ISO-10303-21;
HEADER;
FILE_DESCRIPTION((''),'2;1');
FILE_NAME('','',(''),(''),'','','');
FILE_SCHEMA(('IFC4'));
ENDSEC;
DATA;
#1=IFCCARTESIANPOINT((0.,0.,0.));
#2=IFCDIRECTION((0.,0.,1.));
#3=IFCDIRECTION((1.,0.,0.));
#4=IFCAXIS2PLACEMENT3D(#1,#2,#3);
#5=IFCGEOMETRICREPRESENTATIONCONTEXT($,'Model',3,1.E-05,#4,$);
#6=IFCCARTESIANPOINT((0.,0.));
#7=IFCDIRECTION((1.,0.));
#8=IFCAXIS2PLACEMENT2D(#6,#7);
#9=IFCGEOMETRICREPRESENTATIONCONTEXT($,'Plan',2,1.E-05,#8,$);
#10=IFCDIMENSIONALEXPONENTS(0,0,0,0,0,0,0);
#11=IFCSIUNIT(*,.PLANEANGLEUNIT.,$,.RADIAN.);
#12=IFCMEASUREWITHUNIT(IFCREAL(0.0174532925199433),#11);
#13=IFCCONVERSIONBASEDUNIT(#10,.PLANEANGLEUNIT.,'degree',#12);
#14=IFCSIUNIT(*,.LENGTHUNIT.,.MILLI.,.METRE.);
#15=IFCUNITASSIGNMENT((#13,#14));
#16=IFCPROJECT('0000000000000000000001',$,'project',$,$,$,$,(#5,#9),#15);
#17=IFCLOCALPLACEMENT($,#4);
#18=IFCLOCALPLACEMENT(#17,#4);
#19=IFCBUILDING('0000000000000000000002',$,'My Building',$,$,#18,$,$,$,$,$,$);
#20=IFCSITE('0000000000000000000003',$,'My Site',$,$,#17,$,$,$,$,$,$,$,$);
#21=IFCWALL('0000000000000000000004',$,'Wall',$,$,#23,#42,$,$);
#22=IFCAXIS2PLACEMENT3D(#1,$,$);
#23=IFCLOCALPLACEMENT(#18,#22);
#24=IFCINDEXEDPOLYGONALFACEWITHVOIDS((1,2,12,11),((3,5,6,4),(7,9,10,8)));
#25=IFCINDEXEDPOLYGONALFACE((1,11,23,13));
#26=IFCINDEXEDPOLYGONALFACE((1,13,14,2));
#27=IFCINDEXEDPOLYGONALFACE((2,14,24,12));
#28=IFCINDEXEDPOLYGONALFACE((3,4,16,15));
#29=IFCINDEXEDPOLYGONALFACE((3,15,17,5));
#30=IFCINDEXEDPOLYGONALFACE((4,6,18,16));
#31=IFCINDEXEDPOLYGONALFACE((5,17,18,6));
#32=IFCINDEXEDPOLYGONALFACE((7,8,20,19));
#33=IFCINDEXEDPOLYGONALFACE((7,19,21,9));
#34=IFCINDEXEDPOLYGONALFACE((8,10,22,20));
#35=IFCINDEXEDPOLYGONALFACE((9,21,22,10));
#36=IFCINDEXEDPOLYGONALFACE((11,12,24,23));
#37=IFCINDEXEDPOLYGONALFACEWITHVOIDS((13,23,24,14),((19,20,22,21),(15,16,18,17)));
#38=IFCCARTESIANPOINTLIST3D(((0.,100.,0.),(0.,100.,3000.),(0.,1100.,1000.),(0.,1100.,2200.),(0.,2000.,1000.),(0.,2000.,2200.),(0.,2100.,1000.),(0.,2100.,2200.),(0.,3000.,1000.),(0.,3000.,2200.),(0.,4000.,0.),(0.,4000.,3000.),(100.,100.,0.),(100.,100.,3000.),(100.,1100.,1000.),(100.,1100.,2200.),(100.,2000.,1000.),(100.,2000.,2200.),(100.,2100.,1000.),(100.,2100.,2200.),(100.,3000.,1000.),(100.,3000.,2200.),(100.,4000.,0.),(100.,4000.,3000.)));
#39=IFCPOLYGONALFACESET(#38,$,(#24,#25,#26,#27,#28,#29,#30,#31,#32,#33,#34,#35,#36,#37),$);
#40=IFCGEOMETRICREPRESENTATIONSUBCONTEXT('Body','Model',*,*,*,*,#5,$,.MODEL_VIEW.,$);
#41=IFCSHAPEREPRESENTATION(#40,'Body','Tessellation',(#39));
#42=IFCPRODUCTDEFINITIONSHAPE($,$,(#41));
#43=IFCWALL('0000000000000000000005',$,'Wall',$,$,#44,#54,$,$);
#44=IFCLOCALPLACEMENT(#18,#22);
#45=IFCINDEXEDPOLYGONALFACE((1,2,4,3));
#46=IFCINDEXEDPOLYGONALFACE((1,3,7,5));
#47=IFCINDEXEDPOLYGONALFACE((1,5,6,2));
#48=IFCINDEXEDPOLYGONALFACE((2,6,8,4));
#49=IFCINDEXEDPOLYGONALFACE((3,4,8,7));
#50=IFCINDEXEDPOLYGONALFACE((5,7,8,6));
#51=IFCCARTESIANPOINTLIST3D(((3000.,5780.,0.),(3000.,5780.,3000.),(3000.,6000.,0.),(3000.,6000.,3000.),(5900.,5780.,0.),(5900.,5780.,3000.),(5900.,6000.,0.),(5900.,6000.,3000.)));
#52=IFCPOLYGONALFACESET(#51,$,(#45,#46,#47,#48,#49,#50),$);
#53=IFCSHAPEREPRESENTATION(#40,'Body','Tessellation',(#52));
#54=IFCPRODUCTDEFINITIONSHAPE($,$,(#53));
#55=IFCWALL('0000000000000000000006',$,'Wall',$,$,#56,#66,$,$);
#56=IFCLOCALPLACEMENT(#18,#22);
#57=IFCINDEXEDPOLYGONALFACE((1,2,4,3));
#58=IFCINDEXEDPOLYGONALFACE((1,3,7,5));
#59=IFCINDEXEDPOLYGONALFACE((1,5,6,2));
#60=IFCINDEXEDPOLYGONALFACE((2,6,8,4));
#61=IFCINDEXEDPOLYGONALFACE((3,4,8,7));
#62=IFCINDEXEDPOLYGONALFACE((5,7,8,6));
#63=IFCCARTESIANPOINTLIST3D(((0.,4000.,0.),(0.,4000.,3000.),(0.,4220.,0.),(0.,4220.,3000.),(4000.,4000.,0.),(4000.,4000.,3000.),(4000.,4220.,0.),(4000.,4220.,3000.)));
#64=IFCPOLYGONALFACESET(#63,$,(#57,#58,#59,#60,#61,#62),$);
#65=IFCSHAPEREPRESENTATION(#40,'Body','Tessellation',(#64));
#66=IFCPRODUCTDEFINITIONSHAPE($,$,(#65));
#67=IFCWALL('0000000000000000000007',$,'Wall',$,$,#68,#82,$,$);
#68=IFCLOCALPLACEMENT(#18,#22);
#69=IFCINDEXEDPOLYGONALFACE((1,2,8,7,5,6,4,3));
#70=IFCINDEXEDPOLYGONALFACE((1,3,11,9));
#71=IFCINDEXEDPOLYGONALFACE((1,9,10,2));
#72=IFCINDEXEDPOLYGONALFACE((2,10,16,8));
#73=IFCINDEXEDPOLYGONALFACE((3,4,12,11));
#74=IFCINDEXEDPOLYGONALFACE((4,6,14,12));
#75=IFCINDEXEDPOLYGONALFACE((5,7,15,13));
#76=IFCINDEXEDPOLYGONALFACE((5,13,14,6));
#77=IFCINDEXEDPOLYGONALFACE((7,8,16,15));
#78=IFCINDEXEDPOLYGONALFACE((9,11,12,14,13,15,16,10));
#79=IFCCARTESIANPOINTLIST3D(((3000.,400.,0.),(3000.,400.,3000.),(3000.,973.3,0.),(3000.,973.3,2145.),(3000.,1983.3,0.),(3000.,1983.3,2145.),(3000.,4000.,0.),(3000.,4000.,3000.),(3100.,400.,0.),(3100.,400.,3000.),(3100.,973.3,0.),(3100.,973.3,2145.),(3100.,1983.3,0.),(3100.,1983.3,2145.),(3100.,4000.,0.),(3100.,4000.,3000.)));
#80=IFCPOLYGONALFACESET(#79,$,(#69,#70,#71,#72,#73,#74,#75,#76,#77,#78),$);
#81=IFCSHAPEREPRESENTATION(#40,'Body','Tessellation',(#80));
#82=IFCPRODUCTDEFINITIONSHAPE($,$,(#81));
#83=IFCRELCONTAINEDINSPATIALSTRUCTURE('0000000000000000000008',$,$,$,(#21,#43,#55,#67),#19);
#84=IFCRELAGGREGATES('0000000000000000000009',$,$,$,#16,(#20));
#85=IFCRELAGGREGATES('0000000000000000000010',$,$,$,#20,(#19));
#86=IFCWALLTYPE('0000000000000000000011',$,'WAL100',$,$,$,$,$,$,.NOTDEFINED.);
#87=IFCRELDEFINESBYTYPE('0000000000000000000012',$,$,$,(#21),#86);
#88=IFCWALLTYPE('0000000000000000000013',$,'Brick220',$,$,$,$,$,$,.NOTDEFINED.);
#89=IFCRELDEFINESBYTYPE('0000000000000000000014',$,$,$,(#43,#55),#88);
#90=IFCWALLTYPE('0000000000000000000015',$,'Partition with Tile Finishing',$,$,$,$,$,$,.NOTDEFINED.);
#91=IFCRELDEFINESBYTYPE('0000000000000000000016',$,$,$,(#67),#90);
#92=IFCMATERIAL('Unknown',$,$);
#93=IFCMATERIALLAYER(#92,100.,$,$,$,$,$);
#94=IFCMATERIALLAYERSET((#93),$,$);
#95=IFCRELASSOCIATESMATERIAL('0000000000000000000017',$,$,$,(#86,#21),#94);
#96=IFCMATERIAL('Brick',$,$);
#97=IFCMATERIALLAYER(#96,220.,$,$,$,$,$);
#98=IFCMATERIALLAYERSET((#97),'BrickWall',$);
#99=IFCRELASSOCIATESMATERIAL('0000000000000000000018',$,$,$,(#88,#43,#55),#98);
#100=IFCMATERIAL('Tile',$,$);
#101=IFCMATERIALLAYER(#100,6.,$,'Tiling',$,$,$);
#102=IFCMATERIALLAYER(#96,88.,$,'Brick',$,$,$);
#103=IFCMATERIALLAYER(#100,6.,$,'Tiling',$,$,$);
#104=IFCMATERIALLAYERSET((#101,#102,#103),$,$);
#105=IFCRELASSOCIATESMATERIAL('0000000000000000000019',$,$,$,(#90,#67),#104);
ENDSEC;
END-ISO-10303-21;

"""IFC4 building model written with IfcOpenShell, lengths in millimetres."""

from ifc_helpers import new_model, entity, si_unit, converted_unit, frame, origin_with_axes, origin_2d_with_axis, place, context, subcontext, project, spatial, line, indexed_curve, outline, extrude, source, transform, mapped, material, layer, layer_set, layer_usage, type_object, element, save


model = new_model("IFC4")

# Units and contexts
model_context = context("Model", 3, precision=1e-05, world=origin_with_axes())
plan_context = context("Plan", 2, precision=1e-05, world=origin_2d_with_axis())
body_context = subcontext(model_context, "Body", "Model", "MODEL_VIEW")
ifc_project = project(units=[converted_unit("PLANEANGLEUNIT", "degree", entity("IfcReal", 0.0174532925199433), si_unit("PLANEANGLEUNIT", "RADIAN"), dimensions=[0, 0, 0, 0, 0, 0, 0]), si_unit("LENGTHUNIT", "METRE", prefix="MILLI")], contexts=[model_context, plan_context])

# Site, building
site_placement = place(None, origin_with_axes())
site = spatial("IfcSite", under=ifc_project, at=site_placement, Name="My Site")
building_placement = place(site_placement, origin_with_axes())
building = spatial("IfcBuilding", under=site, at=building_placement, Name="My Building")

# Shared definitions
ifc_material_1 = material(Name="Unknown")

# Shared definitions
ifc_layer_1 = layer(ifc_material_1, 100.0)
ifc_layer_set_1 = layer_set([ifc_layer_1])
wall_type_1 = type_object("IfcWallType", Name="WAL100", PredefinedType="NOTDEFINED", material=ifc_layer_set_1)
shared_shape_1 = source(origin_with_axes(), body_context, "Body", "SweptSolid", [
    extrude(outline(indexed_curve([(0.0, 0.0), (900.0, 0.0), (900.0, 1200.0), (0.0, 1200.0)], segments=[line(1, 2, 3, 4, 1)])), frame((0.0, -600.0, 0.0), z_axis=(0.0, -1.0, 0.0), x_axis=(1.0, 0.0, 0.0)), (0.0, 0.0, -1.0), 1200.0),
])

# Shared definitions
shared_shape_2 = source(origin_with_axes(), body_context, "Body", "SweptSolid", [
    extrude(outline(indexed_curve([(0.0, 0.0), (1010.0, 0.0), (1010.0, 2145.0), (0.0, 2145.0)], segments=[line(1, 2, 3, 4, 1)])), frame((0.0, -600.0, 0.0), z_axis=(0.0, -1.0, 0.0), x_axis=(1.0, 0.0, 0.0)), (0.0, 0.0, -1.0), 1200.0),
])

# Wall, openings
ifc_layer_usage_1 = layer_usage(ifc_layer_set_1, "AXIS2", "POSITIVE", 0.0)
wall_1_placement = place(building_placement, frame((0.0, 4000.0, 0.0), z_axis=(0.0, 0.0, 1.0), x_axis=(0.0, -1.0, 0.0)))
wall_1 = element("IfcWall", 1, at=wall_1_placement, inside=building, type_object=wall_type_1, material=ifc_layer_usage_1, Name="Wall", context=body_context, shape_type="SweptSolid", body=[
    extrude(outline(indexed_curve([(0.0, 0.0), (0.0, 100.0), (3900.0, 100.0), (3900.0, 0.0), (0.0, 0.0)], self_intersect=False)), origin_with_axes(), (0.0, 0.0, 1.0), 3000.0),
])
opening_1_placement = place(wall_1_placement, frame((1000.0, 0.0, 1000.0), z_axis=(0.0, 0.0, 1.0), x_axis=(1.0, 0.0, 0.0)))
element("IfcOpeningElement", 2, at=opening_1_placement, cuts=wall_1, PredefinedType="OPENING", context=body_context, shape_type="MappedRepresentation", body=[
    mapped(shared_shape_1, transform((0.0, 0.0, 0.0), x_axis=(1.0, 0.0, 0.0), y_axis=(0.0, 1.0, 0.0), z_axis=(0.0, 0.0, 1.0), scale=1.0)),
])
opening_2_placement = place(wall_1_placement, frame((2000.0, 0.0, 1000.0), z_axis=(0.0, 0.0, 1.0), x_axis=(1.0, 0.0, 0.0)))
element("IfcOpeningElement", 3, at=opening_2_placement, cuts=wall_1, PredefinedType="OPENING", context=body_context, shape_type="MappedRepresentation", body=[
    mapped(shared_shape_1, transform((0.0, 0.0, 0.0), x_axis=(1.0, 0.0, 0.0), y_axis=(0.0, 1.0, 0.0), z_axis=(0.0, 0.0, 1.0), scale=1.0)),
])

# Walls
ifc_material_2 = material(Name="Brick")
ifc_layer_2 = layer(ifc_material_2, 220.0)
ifc_layer_set_2 = layer_set([ifc_layer_2], Name="BrickWall")
ifc_layer_usage_2 = layer_usage(ifc_layer_set_2, "AXIS2", "POSITIVE", 0.0)
wall_type_2 = type_object("IfcWallType", Name="Brick220", PredefinedType="NOTDEFINED", material=ifc_layer_set_2)
wall_2_placement = place(building_placement, frame((5900.0, 6000.0, 0.0), z_axis=(0.0, 0.0, 1.0), x_axis=(-1.0, 0.000001, 0.0)))
element("IfcWall", 4, at=wall_2_placement, inside=building, type_object=wall_type_2, material=ifc_layer_usage_2, Name="Wall", context=body_context, shape_type="SweptSolid", body=[
    extrude(outline(indexed_curve([(0.0, 0.0), (0.0, 220.0), (2900.0, 220.0), (2900.0, 0.0), (0.0, 0.0)], self_intersect=False)), origin_with_axes(), (0.0, 0.0, 1.0), 3000.0),
])
ifc_layer_usage_3 = layer_usage(ifc_layer_set_2, "AXIS2", "POSITIVE", 0.0)
wall_3_placement = place(building_placement, frame((0.0, 4000.0, 0.0), z_axis=(0.0, 0.0, 1.0), x_axis=(1.0, 0.0, 0.0)))
element("IfcWall", 5, at=wall_3_placement, inside=building, type_object=wall_type_2, material=ifc_layer_usage_3, Name="Wall", context=body_context, shape_type="SweptSolid", body=[
    extrude(outline(indexed_curve([(0.0, 0.0), (0.0, 220.0), (4000.0, 220.0), (4000.0, 0.0), (0.0, 0.0)], self_intersect=False)), origin_with_axes(), (0.0, 0.0, 1.0), 3000.0),
])

# Wall, opening
ifc_material_3 = material(Name="Tile")
ifc_layer_3 = layer(ifc_material_3, 6.0, Name="Tiling")
ifc_layer_4 = layer(ifc_material_2, 88.0, Name="Brick")
ifc_layer_5 = layer(ifc_material_3, 6.0, Name="Tiling")
ifc_layer_set_3 = layer_set([ifc_layer_3, ifc_layer_4, ifc_layer_5])
ifc_layer_usage_4 = layer_usage(ifc_layer_set_3, "AXIS2", "POSITIVE", 0.0)
wall_type_3 = type_object("IfcWallType", Name="Partition with Tile Finishing", PredefinedType="NOTDEFINED", material=ifc_layer_set_3)
wall_4_placement = place(building_placement, frame((3000.0, 4000.0, 0.0), z_axis=(0.0, 0.0, 1.0), x_axis=(0.0, -1.0, 0.0)))
wall_4 = element("IfcWall", 6, at=wall_4_placement, inside=building, type_object=wall_type_3, material=ifc_layer_usage_4, Name="Wall", context=body_context, shape_type="SweptSolid", body=[
    extrude(outline(indexed_curve([(0.0, 0.0), (0.0, 100.0), (3600.0, 100.0), (3600.0, 0.0), (0.0, 0.0)], self_intersect=False)), origin_with_axes(), (0.0, 0.0, 1.0), 3000.0),
])
opening_3_placement = place(wall_4_placement, frame((2016.7, 0.0, 0.0), z_axis=(0.0, 0.0, 1.0), x_axis=(1.0, 0.0, 0.0)))
element("IfcOpeningElement", 7, at=opening_3_placement, cuts=wall_4, PredefinedType="OPENING", context=body_context, shape_type="MappedRepresentation", body=[
    mapped(shared_shape_2, transform((0.0, 0.0, 0.0), x_axis=(1.0, 0.0, 0.0), y_axis=(0.0, 1.0, 0.0), z_axis=(0.0, 0.0, 1.0), scale=1.0)),
])

save(model, "model.ifc")
